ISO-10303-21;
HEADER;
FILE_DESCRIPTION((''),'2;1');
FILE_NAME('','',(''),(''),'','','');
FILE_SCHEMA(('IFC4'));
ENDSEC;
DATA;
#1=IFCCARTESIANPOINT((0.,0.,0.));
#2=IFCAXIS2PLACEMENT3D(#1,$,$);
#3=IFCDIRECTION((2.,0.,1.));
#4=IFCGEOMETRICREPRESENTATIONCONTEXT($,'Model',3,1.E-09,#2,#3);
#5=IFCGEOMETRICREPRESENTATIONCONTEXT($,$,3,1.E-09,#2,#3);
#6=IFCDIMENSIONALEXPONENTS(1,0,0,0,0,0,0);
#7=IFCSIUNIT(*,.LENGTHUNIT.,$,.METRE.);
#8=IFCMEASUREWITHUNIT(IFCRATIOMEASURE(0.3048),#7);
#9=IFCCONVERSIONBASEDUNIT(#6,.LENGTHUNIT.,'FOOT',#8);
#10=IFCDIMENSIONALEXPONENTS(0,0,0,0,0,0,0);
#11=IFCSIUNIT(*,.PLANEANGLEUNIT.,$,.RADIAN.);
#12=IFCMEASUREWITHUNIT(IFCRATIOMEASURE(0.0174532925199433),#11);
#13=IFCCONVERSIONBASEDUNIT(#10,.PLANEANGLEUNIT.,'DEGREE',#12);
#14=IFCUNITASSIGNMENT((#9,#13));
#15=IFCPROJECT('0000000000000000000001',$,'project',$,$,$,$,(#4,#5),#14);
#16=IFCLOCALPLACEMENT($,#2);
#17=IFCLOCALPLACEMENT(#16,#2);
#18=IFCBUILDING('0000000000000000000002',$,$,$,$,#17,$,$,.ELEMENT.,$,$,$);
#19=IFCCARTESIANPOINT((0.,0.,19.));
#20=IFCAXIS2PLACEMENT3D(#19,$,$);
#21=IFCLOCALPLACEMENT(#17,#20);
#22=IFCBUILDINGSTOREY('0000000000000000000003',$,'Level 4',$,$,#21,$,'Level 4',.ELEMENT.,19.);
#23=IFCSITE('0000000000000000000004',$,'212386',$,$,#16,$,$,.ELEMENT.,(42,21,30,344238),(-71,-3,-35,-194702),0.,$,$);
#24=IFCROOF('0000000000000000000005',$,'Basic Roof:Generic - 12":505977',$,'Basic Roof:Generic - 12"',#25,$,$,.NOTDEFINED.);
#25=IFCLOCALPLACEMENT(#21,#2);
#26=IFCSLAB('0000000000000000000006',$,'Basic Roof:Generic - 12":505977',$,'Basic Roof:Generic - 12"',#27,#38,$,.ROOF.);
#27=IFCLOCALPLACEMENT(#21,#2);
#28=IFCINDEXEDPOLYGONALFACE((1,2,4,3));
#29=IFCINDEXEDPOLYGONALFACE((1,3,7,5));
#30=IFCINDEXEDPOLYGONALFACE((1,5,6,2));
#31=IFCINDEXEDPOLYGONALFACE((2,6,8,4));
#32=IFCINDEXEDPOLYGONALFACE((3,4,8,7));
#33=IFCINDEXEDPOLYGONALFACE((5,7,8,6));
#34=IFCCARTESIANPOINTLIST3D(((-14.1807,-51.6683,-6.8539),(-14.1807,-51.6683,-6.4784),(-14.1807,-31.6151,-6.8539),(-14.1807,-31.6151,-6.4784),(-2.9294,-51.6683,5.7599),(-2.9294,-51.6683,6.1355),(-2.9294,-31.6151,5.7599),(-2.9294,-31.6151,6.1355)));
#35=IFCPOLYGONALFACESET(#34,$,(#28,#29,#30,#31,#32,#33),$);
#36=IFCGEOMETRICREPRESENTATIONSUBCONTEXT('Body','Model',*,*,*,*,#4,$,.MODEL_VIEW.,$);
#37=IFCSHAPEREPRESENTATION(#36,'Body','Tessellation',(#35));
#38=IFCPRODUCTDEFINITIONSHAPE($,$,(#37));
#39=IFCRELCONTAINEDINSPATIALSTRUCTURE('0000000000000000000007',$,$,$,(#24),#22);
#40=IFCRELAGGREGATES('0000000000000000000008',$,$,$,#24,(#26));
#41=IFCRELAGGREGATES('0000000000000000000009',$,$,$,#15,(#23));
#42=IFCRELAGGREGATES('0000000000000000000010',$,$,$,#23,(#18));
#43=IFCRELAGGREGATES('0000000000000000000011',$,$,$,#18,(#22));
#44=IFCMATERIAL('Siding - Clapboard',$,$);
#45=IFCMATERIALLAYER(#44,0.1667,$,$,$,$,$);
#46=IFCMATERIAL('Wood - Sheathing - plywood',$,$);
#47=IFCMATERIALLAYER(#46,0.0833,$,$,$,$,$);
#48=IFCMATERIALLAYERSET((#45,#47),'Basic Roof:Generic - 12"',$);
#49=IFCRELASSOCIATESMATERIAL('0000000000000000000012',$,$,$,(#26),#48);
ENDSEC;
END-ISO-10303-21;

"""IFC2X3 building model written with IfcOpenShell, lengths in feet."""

from ifc_helpers import new_model, entity, si_unit, converted_unit, direction, frame, origin, origin_2d_with_axis, place, context, subcontext, project, spatial, rectangle, extrude, material, layer, layer_set, element, aggregate, save


model = new_model("IFC2X3")

# Units and contexts
model_context = context("Model", 3, precision=1e-09, world=origin(), true_north=direction((2.0, 0.0, 1.0)))
context_of_model = context(None, 3, precision=1e-09, world=origin(), true_north=direction((2.0, 0.0, 1.0)))
body_context = subcontext(model_context, "Body", "Model", "MODEL_VIEW")
ifc_project = project(units=[converted_unit("LENGTHUNIT", "FOOT", entity("IfcRatioMeasure", 0.3048), si_unit("LENGTHUNIT", "METRE"), dimensions=[1, 0, 0, 0, 0, 0, 0]), converted_unit("PLANEANGLEUNIT", "DEGREE", entity("IfcRatioMeasure", 0.0174532925199433), si_unit("PLANEANGLEUNIT", "RADIAN"), dimensions=[0, 0, 0, 0, 0, 0, 0])], contexts=[model_context, context_of_model])

# Site, building, storey
site_placement = place(None, origin())
site = spatial("IfcSite", under=ifc_project, at=site_placement, Name="212386", CompositionType="ELEMENT", RefLatitude=(42, 21, 30, 344238), RefLongitude=(-71, -3, -35, -194702), RefElevation=0.0)
building_placement = place(site_placement, origin())
building = spatial("IfcBuilding", under=site, at=building_placement, CompositionType="ELEMENT")
storey_placement = place(building_placement, frame((0.0, 0.0, 19.0)))
storey = spatial("IfcBuildingStorey", under=building, at=storey_placement, Name="Level 4", LongName="Level 4", CompositionType="ELEMENT", Elevation=19.0)

# Roof, slab
roof_placement = place(storey_placement, origin())
roof = element("IfcRoof", 1, at=roof_placement, inside=storey, Name="Basic Roof:Generic - 12\":505977", ObjectType="Basic Roof:Generic - 12\"", ShapeType="NOTDEFINED")
ifc_material_1 = material(Name="Siding - Clapboard")
ifc_layer_1 = layer(ifc_material_1, 0.1667)
ifc_material_2 = material(Name="Wood - Sheathing - plywood")
ifc_layer_2 = layer(ifc_material_2, 0.0833)
ifc_layer_set = layer_set([ifc_layer_1, ifc_layer_2], Name="Basic Roof:Generic - 12\"")
slab_1_placement = place(roof_placement, frame((-14.1807, -51.6683, -6.8539)))
slab_1 = element("IfcSlab", 2, at=slab_1_placement, material=ifc_layer_set, Name="Basic Roof:Generic - 12\":505977", ObjectType="Basic Roof:Generic - 12\"", PredefinedType="ROOF", context=body_context, shape_type="SweptSolid", body=[
    extrude(rectangle(XDim=16.9027, YDim=20.0533, at=origin_2d_with_axis()), frame((5.6257, 10.0266, 6.3069), z_axis=(-0.746262, 0.0, 0.665653), x_axis=(0.665653, 0.0, 0.746262)), (0.746262, 0.0, 0.665653), 0.3756),
])
aggregate(roof, [slab_1])

save(model, "model.ifc")
